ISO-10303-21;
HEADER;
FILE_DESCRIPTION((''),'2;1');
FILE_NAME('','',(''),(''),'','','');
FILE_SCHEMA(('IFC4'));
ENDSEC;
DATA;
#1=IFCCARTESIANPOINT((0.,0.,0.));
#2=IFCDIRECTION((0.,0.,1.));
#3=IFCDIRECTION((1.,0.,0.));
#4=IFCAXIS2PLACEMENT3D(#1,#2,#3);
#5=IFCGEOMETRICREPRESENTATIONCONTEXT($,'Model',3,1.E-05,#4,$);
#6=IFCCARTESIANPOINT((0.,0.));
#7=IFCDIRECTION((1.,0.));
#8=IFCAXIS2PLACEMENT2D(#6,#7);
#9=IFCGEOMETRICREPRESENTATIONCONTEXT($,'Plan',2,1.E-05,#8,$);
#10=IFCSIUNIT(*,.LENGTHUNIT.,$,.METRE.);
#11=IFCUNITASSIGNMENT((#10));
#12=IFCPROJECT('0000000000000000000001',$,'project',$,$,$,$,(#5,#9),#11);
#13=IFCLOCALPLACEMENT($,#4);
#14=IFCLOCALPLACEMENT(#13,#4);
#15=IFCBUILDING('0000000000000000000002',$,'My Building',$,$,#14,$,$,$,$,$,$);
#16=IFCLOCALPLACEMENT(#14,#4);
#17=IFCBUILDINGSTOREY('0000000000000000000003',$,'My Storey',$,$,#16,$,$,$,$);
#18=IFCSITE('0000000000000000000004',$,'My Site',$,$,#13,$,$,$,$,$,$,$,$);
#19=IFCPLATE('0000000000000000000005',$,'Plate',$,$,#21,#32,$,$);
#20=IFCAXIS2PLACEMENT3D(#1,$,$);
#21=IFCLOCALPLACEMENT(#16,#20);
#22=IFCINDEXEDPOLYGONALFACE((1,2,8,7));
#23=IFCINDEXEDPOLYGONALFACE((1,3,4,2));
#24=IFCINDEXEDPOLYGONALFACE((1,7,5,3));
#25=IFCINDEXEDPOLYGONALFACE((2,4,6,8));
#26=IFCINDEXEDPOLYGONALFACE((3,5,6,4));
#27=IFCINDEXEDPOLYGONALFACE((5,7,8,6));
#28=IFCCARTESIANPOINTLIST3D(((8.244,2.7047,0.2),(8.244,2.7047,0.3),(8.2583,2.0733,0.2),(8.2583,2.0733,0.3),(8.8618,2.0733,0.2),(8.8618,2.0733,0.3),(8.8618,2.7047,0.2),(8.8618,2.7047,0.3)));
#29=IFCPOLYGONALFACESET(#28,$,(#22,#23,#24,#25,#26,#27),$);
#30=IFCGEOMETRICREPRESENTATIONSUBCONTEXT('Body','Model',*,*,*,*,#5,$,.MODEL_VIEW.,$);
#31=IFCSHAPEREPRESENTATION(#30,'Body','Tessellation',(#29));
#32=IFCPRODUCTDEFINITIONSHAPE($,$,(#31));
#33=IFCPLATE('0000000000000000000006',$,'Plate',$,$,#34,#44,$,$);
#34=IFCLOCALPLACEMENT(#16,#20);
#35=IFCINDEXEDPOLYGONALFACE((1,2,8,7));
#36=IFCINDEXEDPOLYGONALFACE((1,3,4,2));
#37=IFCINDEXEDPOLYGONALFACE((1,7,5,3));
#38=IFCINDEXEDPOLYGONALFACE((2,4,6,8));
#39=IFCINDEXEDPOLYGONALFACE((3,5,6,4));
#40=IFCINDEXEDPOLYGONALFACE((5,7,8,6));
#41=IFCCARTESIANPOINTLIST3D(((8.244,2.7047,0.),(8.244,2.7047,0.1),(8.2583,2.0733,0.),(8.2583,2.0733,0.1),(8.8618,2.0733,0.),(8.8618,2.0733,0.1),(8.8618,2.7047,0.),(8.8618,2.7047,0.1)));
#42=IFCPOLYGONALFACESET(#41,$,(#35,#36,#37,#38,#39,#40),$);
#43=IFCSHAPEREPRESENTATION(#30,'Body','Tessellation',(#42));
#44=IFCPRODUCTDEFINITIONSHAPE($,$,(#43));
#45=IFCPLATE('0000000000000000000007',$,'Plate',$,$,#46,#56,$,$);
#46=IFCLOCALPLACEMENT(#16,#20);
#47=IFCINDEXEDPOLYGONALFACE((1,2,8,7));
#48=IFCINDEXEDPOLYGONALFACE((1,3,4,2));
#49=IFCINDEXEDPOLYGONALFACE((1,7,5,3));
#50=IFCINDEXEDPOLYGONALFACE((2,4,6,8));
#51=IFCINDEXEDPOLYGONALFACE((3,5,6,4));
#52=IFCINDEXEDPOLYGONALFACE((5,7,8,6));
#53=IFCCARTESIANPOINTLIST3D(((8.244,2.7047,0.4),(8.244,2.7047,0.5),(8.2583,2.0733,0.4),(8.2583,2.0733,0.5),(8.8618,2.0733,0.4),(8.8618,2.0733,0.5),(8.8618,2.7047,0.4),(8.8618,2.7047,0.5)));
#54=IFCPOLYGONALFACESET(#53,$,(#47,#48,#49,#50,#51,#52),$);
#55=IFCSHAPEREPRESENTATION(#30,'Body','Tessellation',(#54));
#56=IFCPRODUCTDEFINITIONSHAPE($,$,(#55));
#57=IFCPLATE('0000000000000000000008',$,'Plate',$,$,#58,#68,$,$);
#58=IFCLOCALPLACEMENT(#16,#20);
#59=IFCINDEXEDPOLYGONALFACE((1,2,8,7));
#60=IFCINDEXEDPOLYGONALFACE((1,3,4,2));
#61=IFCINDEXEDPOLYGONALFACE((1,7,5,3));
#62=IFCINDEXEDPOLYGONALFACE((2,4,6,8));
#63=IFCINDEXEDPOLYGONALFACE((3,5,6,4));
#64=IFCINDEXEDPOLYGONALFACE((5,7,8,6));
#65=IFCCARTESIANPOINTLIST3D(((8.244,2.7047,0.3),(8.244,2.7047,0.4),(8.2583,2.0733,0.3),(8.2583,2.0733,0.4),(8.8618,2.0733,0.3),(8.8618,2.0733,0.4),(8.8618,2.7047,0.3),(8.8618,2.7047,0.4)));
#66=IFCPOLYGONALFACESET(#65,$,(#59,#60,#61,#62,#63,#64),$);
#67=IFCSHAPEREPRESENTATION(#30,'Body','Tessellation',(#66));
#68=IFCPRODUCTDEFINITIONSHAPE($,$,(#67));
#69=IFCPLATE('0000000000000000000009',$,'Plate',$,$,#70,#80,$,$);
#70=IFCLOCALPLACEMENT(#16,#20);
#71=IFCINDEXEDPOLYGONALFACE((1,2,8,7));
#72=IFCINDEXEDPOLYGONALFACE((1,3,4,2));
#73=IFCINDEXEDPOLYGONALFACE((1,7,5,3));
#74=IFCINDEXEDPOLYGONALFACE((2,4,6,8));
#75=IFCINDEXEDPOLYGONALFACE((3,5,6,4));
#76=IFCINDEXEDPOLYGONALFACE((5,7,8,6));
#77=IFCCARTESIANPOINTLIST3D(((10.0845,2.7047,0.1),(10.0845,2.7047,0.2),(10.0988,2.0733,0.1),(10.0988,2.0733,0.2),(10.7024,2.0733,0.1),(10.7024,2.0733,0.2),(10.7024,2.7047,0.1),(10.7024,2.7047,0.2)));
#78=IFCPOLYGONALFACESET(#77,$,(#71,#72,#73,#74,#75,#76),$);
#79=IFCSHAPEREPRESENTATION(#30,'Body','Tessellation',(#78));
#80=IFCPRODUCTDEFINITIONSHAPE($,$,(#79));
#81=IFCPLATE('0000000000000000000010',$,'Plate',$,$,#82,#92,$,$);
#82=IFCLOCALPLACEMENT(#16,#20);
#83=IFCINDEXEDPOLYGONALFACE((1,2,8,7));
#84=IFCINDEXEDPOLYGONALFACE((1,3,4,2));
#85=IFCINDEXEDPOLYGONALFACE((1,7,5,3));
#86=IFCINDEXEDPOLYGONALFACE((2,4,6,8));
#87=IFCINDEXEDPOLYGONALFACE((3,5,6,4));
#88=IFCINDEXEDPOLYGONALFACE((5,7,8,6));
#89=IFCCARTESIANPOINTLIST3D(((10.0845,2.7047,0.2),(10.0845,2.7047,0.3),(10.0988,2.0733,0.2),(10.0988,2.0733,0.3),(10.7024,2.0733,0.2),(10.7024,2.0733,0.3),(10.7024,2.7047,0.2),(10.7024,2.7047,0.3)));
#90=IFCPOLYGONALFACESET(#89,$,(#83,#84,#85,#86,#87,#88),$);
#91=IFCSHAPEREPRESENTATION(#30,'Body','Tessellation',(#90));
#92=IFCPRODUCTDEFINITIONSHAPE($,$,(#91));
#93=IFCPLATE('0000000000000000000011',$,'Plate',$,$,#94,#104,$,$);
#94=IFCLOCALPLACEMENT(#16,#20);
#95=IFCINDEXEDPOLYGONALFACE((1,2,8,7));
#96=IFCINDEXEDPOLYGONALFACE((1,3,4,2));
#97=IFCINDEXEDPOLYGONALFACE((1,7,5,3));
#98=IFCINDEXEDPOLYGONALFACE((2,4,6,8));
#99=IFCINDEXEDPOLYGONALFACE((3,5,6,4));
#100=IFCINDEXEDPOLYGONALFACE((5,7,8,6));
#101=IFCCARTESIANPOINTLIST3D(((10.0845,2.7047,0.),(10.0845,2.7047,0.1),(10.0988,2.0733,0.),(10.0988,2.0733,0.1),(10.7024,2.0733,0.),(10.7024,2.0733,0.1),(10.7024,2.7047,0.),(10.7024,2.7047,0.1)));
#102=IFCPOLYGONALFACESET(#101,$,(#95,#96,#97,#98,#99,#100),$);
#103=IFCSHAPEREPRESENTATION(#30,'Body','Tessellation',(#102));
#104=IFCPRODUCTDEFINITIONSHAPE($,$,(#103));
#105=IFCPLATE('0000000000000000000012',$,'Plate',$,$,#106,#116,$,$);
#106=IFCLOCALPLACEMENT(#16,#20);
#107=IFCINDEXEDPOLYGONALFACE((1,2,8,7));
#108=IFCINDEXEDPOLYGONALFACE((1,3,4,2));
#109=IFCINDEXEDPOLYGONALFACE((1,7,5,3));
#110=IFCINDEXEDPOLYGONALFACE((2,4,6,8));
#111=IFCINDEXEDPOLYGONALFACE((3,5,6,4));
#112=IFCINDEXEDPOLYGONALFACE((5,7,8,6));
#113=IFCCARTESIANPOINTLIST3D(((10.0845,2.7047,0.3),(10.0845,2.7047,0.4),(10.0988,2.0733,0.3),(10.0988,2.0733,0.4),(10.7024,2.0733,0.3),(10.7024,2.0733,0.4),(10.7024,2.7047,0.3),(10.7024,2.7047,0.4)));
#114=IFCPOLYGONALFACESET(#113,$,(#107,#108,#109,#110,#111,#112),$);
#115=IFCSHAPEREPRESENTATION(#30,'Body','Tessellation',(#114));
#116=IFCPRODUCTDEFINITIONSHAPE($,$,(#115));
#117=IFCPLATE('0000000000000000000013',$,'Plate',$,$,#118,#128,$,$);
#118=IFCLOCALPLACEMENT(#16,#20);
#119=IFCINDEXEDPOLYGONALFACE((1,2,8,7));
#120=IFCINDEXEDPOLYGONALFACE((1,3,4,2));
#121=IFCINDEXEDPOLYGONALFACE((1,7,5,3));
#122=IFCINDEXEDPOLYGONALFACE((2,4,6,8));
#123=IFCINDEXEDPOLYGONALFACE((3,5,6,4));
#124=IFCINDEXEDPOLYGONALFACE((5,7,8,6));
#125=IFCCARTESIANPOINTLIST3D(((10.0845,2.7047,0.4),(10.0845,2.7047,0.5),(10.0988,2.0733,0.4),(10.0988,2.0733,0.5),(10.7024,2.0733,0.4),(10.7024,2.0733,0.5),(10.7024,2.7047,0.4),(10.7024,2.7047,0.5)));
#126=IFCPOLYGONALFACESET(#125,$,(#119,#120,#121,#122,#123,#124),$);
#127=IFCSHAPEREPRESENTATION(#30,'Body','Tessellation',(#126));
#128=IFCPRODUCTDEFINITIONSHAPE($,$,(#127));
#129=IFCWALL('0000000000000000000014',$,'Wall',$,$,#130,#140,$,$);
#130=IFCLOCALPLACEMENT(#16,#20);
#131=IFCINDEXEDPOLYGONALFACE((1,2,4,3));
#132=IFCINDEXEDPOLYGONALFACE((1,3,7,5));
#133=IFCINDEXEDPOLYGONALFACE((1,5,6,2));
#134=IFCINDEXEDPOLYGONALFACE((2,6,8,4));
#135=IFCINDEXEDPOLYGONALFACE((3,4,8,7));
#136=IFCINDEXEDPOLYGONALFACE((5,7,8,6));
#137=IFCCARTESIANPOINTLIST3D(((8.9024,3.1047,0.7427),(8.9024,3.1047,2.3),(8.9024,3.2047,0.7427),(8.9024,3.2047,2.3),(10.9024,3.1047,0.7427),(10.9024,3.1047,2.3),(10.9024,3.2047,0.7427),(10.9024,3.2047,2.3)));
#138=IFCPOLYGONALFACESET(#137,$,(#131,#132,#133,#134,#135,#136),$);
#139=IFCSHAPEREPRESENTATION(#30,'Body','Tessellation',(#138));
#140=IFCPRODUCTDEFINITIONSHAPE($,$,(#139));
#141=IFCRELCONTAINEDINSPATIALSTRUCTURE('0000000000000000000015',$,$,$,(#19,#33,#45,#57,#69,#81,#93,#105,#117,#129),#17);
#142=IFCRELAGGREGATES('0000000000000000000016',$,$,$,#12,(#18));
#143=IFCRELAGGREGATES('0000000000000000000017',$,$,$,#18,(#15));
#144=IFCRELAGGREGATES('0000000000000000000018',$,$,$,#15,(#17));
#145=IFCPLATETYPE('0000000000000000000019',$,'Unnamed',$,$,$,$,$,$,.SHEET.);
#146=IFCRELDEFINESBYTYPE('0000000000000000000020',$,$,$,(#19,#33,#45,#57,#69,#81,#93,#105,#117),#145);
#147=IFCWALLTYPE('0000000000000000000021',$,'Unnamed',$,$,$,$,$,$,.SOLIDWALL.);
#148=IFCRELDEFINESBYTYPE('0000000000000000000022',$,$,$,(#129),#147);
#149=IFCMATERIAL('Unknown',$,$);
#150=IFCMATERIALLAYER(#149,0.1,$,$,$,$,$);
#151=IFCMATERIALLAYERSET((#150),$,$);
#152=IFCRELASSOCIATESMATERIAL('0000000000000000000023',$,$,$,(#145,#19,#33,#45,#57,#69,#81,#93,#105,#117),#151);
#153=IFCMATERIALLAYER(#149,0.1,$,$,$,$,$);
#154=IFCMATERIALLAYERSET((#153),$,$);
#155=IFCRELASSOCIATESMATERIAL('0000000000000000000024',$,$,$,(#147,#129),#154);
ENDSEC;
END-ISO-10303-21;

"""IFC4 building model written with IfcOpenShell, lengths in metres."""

from ifc_helpers import new_model, si_unit, frame, origin_with_axes, origin_2d_with_axis, place, context, subcontext, project, spatial, line, indexed_curve, outline, extrude, material, layer, layer_set, layer_usage, type_object, element, save


model = new_model("IFC4")

# Units and contexts
model_context = context("Model", 3, precision=1e-05, world=origin_with_axes())
plan_context = context("Plan", 2, precision=1e-05, world=origin_2d_with_axis())
body_context = subcontext(model_context, "Body", "Model", "MODEL_VIEW")
ifc_project = project(units=[si_unit("LENGTHUNIT", "METRE")], contexts=[model_context, plan_context])

# Site, building, storey
site_placement = place(None, origin_with_axes())
site = spatial("IfcSite", under=ifc_project, at=site_placement, Name="My Site")
building_placement = place(site_placement, origin_with_axes())
building = spatial("IfcBuilding", under=site, at=building_placement, Name="My Building")
storey_placement = place(building_placement, origin_with_axes())
storey = spatial("IfcBuildingStorey", under=building, at=storey_placement, Name="My Storey")

# Shared definitions
ifc_material = material(Name="Unknown")

# Plates
ifc_layer_1 = layer(ifc_material, 0.1)
ifc_layer_set_1 = layer_set([ifc_layer_1])
plate_type = type_object("IfcPlateType", Name="Unnamed", PredefinedType="SHEET", material=ifc_layer_set_1)
ifc_layer_usage_1 = layer_usage(ifc_layer_set_1, "AXIS3", "POSITIVE", -0.1)
plate_1_placement = place(storey_placement, frame((8.2583, 2.0733, 0.3), z_axis=(0.0, 0.0, 1.0), x_axis=(1.0, 0.0, 0.0)))
element("IfcPlate", 1, at=plate_1_placement, inside=storey, type_object=plate_type, material=ifc_layer_usage_1, Name="Plate", context=body_context, shape_type="SweptSolid", body=[
    extrude(outline(indexed_curve([(0.0, 0.0), (0.6036, 0.0), (0.6036, 0.6314), (-0.0143, 0.6314), (0.0, 0.0)])), frame((0.0, 0.0, -0.1), z_axis=(0.0, 0.0, 1.0), x_axis=(1.0, 0.0, 0.0)), (0.0, 0.0, 1.0), 0.1),
])
ifc_layer_usage_2 = layer_usage(ifc_layer_set_1, "AXIS3", "POSITIVE", -0.1)
plate_2_placement = place(storey_placement, frame((8.2583, 2.0733, 0.1), z_axis=(0.0, 0.0, 1.0), x_axis=(1.0, 0.0, 0.0)))
element("IfcPlate", 2, at=plate_2_placement, inside=storey, type_object=plate_type, material=ifc_layer_usage_2, Name="Plate", context=body_context, shape_type="SweptSolid", body=[
    extrude(outline(indexed_curve([(0.0, 0.0), (0.6036, 0.0), (0.6036, 0.6314), (-0.0143, 0.6314), (0.0, 0.0)])), frame((0.0, 0.0, -0.1), z_axis=(0.0, 0.0, 1.0), x_axis=(1.0, 0.0, 0.0)), (0.0, 0.0, 1.0), 0.1),
])
ifc_layer_usage_3 = layer_usage(ifc_layer_set_1, "AXIS3", "POSITIVE", -0.1)
plate_3_placement = place(storey_placement, frame((8.2583, 2.0733, 0.5), z_axis=(0.0, 0.0, 1.0), x_axis=(1.0, 0.0, 0.0)))
element("IfcPlate", 3, at=plate_3_placement, inside=storey, type_object=plate_type, material=ifc_layer_usage_3, Name="Plate", context=body_context, shape_type="SweptSolid", body=[
    extrude(outline(indexed_curve([(0.0, 0.0), (0.6036, 0.0), (0.6036, 0.6314), (-0.0143, 0.6314), (0.0, 0.0)])), frame((0.0, 0.0, -0.1), z_axis=(0.0, 0.0, 1.0), x_axis=(1.0, 0.0, 0.0)), (0.0, 0.0, 1.0), 0.1),
])
ifc_layer_usage_4 = layer_usage(ifc_layer_set_1, "AXIS3", "POSITIVE", -0.1)
plate_4_placement = place(storey_placement, frame((8.2583, 2.0733, 0.4), z_axis=(0.0, 0.0, 1.0), x_axis=(1.0, 0.0, 0.0)))
element("IfcPlate", 4, at=plate_4_placement, inside=storey, type_object=plate_type, material=ifc_layer_usage_4, Name="Plate", context=body_context, shape_type="SweptSolid", body=[
    extrude(outline(indexed_curve([(0.0, 0.0), (0.6036, 0.0), (0.6036, 0.6314), (-0.0143, 0.6314), (0.0, 0.0)])), frame((0.0, 0.0, -0.1), z_axis=(0.0, 0.0, 1.0), x_axis=(1.0, 0.0, 0.0)), (0.0, 0.0, 1.0), 0.1),
])
ifc_layer_usage_5 = layer_usage(ifc_layer_set_1, "AXIS3", "POSITIVE", -0.1)
plate_5_placement = place(storey_placement, frame((10.0988, 2.0733, 0.2), z_axis=(0.0, 0.0, 1.0), x_axis=(1.0, 0.0, 0.0)))
element("IfcPlate", 5, at=plate_5_placement, inside=storey, type_object=plate_type, material=ifc_layer_usage_5, Name="Plate", context=body_context, shape_type="SweptSolid", body=[
    extrude(outline(indexed_curve([(0.0, 0.0), (0.6036, 0.0), (0.6036, 0.6314), (-0.0143, 0.6314), (0.0, 0.0)])), frame((0.0, 0.0, -0.1), z_axis=(0.0, 0.0, 1.0), x_axis=(1.0, 0.0, 0.0)), (0.0, 0.0, 1.0), 0.1),
])
ifc_layer_usage_6 = layer_usage(ifc_layer_set_1, "AXIS3", "POSITIVE", -0.1)
plate_6_placement = place(storey_placement, frame((10.0988, 2.0733, 0.3), z_axis=(0.0, 0.0, 1.0), x_axis=(1.0, 0.0, 0.0)))
element("IfcPlate", 6, at=plate_6_placement, inside=storey, type_object=plate_type, material=ifc_layer_usage_6, Name="Plate", context=body_context, shape_type="SweptSolid", body=[
    extrude(outline(indexed_curve([(0.0, 0.0), (0.6036, 0.0), (0.6036, 0.6314), (-0.0143, 0.6314), (0.0, 0.0)])), frame((0.0, 0.0, -0.1), z_axis=(0.0, 0.0, 1.0), x_axis=(1.0, 0.0, 0.0)), (0.0, 0.0, 1.0), 0.1),
])
ifc_layer_usage_7 = layer_usage(ifc_layer_set_1, "AXIS3", "POSITIVE", -0.1)
plate_7_placement = place(storey_placement, frame((10.0988, 2.0733, 0.1), z_axis=(0.0, 0.0, 1.0), x_axis=(1.0, 0.0, 0.0)))
element("IfcPlate", 7, at=plate_7_placement, inside=storey, type_object=plate_type, material=ifc_layer_usage_7, Name="Plate", context=body_context, shape_type="SweptSolid", body=[
    extrude(outline(indexed_curve([(0.0, 0.0), (0.6036, 0.0), (0.6036, 0.6314), (-0.0143, 0.6314), (0.0, 0.0)])), frame((0.0, 0.0, -0.1), z_axis=(0.0, 0.0, 1.0), x_axis=(1.0, 0.0, 0.0)), (0.0, 0.0, 1.0), 0.1),
])
ifc_layer_usage_8 = layer_usage(ifc_layer_set_1, "AXIS3", "POSITIVE", -0.1)
plate_8_placement = place(storey_placement, frame((10.0988, 2.0733, 0.4), z_axis=(0.0, 0.0, 1.0), x_axis=(1.0, 0.0, 0.0)))
element("IfcPlate", 8, at=plate_8_placement, inside=storey, type_object=plate_type, material=ifc_layer_usage_8, Name="Plate", context=body_context, shape_type="SweptSolid", body=[
    extrude(outline(indexed_curve([(0.0, 0.0), (0.6036, 0.0), (0.6036, 0.6314), (-0.0143, 0.6314), (0.0, 0.0)])), frame((0.0, 0.0, -0.1), z_axis=(0.0, 0.0, 1.0), x_axis=(1.0, 0.0, 0.0)), (0.0, 0.0, 1.0), 0.1),
])
ifc_layer_usage_9 = layer_usage(ifc_layer_set_1, "AXIS3", "POSITIVE", -0.1)
plate_9_placement = place(storey_placement, frame((10.0988, 2.0733, 0.5), z_axis=(0.0, 0.0, 1.0), x_axis=(1.0, 0.0, 0.0)))
element("IfcPlate", 9, at=plate_9_placement, inside=storey, type_object=plate_type, material=ifc_layer_usage_9, Name="Plate", context=body_context, shape_type="SweptSolid", body=[
    extrude(outline(indexed_curve([(0.0, 0.0), (0.6036, 0.0), (0.6036, 0.6314), (-0.0143, 0.6314), (0.0, 0.0)])), frame((0.0, 0.0, -0.1), z_axis=(0.0, 0.0, 1.0), x_axis=(1.0, 0.0, 0.0)), (0.0, 0.0, 1.0), 0.1),
])

# Wall
ifc_layer_2 = layer(ifc_material, 0.1)
ifc_layer_set_2 = layer_set([ifc_layer_2])
ifc_layer_usage_10 = layer_usage(ifc_layer_set_2, "AXIS2", "POSITIVE", 0.0)
wall_type = type_object("IfcWallType", Name="Unnamed", PredefinedType="SOLIDWALL", material=ifc_layer_set_2)
wall_placement = place(storey_placement, frame((8.9024, 3.1047, 0.7427), z_axis=(0.0, 0.0, 1.0), x_axis=(1.0, 0.0, 0.0)))
element("IfcWall", 10, at=wall_placement, inside=storey, type_object=wall_type, material=ifc_layer_usage_10, Name="Wall", context=body_context, shape_type="SweptSolid", body=[
    extrude(outline(indexed_curve([(0.0, 0.0), (0.0, 0.1), (2.0, 0.1), (2.0, 0.0)], segments=[line(1, 2, 3, 4, 1)])), origin_with_axes(), (0.0, 0.0, 1.0), 1.5573),
])

save(model, "model.ifc")
